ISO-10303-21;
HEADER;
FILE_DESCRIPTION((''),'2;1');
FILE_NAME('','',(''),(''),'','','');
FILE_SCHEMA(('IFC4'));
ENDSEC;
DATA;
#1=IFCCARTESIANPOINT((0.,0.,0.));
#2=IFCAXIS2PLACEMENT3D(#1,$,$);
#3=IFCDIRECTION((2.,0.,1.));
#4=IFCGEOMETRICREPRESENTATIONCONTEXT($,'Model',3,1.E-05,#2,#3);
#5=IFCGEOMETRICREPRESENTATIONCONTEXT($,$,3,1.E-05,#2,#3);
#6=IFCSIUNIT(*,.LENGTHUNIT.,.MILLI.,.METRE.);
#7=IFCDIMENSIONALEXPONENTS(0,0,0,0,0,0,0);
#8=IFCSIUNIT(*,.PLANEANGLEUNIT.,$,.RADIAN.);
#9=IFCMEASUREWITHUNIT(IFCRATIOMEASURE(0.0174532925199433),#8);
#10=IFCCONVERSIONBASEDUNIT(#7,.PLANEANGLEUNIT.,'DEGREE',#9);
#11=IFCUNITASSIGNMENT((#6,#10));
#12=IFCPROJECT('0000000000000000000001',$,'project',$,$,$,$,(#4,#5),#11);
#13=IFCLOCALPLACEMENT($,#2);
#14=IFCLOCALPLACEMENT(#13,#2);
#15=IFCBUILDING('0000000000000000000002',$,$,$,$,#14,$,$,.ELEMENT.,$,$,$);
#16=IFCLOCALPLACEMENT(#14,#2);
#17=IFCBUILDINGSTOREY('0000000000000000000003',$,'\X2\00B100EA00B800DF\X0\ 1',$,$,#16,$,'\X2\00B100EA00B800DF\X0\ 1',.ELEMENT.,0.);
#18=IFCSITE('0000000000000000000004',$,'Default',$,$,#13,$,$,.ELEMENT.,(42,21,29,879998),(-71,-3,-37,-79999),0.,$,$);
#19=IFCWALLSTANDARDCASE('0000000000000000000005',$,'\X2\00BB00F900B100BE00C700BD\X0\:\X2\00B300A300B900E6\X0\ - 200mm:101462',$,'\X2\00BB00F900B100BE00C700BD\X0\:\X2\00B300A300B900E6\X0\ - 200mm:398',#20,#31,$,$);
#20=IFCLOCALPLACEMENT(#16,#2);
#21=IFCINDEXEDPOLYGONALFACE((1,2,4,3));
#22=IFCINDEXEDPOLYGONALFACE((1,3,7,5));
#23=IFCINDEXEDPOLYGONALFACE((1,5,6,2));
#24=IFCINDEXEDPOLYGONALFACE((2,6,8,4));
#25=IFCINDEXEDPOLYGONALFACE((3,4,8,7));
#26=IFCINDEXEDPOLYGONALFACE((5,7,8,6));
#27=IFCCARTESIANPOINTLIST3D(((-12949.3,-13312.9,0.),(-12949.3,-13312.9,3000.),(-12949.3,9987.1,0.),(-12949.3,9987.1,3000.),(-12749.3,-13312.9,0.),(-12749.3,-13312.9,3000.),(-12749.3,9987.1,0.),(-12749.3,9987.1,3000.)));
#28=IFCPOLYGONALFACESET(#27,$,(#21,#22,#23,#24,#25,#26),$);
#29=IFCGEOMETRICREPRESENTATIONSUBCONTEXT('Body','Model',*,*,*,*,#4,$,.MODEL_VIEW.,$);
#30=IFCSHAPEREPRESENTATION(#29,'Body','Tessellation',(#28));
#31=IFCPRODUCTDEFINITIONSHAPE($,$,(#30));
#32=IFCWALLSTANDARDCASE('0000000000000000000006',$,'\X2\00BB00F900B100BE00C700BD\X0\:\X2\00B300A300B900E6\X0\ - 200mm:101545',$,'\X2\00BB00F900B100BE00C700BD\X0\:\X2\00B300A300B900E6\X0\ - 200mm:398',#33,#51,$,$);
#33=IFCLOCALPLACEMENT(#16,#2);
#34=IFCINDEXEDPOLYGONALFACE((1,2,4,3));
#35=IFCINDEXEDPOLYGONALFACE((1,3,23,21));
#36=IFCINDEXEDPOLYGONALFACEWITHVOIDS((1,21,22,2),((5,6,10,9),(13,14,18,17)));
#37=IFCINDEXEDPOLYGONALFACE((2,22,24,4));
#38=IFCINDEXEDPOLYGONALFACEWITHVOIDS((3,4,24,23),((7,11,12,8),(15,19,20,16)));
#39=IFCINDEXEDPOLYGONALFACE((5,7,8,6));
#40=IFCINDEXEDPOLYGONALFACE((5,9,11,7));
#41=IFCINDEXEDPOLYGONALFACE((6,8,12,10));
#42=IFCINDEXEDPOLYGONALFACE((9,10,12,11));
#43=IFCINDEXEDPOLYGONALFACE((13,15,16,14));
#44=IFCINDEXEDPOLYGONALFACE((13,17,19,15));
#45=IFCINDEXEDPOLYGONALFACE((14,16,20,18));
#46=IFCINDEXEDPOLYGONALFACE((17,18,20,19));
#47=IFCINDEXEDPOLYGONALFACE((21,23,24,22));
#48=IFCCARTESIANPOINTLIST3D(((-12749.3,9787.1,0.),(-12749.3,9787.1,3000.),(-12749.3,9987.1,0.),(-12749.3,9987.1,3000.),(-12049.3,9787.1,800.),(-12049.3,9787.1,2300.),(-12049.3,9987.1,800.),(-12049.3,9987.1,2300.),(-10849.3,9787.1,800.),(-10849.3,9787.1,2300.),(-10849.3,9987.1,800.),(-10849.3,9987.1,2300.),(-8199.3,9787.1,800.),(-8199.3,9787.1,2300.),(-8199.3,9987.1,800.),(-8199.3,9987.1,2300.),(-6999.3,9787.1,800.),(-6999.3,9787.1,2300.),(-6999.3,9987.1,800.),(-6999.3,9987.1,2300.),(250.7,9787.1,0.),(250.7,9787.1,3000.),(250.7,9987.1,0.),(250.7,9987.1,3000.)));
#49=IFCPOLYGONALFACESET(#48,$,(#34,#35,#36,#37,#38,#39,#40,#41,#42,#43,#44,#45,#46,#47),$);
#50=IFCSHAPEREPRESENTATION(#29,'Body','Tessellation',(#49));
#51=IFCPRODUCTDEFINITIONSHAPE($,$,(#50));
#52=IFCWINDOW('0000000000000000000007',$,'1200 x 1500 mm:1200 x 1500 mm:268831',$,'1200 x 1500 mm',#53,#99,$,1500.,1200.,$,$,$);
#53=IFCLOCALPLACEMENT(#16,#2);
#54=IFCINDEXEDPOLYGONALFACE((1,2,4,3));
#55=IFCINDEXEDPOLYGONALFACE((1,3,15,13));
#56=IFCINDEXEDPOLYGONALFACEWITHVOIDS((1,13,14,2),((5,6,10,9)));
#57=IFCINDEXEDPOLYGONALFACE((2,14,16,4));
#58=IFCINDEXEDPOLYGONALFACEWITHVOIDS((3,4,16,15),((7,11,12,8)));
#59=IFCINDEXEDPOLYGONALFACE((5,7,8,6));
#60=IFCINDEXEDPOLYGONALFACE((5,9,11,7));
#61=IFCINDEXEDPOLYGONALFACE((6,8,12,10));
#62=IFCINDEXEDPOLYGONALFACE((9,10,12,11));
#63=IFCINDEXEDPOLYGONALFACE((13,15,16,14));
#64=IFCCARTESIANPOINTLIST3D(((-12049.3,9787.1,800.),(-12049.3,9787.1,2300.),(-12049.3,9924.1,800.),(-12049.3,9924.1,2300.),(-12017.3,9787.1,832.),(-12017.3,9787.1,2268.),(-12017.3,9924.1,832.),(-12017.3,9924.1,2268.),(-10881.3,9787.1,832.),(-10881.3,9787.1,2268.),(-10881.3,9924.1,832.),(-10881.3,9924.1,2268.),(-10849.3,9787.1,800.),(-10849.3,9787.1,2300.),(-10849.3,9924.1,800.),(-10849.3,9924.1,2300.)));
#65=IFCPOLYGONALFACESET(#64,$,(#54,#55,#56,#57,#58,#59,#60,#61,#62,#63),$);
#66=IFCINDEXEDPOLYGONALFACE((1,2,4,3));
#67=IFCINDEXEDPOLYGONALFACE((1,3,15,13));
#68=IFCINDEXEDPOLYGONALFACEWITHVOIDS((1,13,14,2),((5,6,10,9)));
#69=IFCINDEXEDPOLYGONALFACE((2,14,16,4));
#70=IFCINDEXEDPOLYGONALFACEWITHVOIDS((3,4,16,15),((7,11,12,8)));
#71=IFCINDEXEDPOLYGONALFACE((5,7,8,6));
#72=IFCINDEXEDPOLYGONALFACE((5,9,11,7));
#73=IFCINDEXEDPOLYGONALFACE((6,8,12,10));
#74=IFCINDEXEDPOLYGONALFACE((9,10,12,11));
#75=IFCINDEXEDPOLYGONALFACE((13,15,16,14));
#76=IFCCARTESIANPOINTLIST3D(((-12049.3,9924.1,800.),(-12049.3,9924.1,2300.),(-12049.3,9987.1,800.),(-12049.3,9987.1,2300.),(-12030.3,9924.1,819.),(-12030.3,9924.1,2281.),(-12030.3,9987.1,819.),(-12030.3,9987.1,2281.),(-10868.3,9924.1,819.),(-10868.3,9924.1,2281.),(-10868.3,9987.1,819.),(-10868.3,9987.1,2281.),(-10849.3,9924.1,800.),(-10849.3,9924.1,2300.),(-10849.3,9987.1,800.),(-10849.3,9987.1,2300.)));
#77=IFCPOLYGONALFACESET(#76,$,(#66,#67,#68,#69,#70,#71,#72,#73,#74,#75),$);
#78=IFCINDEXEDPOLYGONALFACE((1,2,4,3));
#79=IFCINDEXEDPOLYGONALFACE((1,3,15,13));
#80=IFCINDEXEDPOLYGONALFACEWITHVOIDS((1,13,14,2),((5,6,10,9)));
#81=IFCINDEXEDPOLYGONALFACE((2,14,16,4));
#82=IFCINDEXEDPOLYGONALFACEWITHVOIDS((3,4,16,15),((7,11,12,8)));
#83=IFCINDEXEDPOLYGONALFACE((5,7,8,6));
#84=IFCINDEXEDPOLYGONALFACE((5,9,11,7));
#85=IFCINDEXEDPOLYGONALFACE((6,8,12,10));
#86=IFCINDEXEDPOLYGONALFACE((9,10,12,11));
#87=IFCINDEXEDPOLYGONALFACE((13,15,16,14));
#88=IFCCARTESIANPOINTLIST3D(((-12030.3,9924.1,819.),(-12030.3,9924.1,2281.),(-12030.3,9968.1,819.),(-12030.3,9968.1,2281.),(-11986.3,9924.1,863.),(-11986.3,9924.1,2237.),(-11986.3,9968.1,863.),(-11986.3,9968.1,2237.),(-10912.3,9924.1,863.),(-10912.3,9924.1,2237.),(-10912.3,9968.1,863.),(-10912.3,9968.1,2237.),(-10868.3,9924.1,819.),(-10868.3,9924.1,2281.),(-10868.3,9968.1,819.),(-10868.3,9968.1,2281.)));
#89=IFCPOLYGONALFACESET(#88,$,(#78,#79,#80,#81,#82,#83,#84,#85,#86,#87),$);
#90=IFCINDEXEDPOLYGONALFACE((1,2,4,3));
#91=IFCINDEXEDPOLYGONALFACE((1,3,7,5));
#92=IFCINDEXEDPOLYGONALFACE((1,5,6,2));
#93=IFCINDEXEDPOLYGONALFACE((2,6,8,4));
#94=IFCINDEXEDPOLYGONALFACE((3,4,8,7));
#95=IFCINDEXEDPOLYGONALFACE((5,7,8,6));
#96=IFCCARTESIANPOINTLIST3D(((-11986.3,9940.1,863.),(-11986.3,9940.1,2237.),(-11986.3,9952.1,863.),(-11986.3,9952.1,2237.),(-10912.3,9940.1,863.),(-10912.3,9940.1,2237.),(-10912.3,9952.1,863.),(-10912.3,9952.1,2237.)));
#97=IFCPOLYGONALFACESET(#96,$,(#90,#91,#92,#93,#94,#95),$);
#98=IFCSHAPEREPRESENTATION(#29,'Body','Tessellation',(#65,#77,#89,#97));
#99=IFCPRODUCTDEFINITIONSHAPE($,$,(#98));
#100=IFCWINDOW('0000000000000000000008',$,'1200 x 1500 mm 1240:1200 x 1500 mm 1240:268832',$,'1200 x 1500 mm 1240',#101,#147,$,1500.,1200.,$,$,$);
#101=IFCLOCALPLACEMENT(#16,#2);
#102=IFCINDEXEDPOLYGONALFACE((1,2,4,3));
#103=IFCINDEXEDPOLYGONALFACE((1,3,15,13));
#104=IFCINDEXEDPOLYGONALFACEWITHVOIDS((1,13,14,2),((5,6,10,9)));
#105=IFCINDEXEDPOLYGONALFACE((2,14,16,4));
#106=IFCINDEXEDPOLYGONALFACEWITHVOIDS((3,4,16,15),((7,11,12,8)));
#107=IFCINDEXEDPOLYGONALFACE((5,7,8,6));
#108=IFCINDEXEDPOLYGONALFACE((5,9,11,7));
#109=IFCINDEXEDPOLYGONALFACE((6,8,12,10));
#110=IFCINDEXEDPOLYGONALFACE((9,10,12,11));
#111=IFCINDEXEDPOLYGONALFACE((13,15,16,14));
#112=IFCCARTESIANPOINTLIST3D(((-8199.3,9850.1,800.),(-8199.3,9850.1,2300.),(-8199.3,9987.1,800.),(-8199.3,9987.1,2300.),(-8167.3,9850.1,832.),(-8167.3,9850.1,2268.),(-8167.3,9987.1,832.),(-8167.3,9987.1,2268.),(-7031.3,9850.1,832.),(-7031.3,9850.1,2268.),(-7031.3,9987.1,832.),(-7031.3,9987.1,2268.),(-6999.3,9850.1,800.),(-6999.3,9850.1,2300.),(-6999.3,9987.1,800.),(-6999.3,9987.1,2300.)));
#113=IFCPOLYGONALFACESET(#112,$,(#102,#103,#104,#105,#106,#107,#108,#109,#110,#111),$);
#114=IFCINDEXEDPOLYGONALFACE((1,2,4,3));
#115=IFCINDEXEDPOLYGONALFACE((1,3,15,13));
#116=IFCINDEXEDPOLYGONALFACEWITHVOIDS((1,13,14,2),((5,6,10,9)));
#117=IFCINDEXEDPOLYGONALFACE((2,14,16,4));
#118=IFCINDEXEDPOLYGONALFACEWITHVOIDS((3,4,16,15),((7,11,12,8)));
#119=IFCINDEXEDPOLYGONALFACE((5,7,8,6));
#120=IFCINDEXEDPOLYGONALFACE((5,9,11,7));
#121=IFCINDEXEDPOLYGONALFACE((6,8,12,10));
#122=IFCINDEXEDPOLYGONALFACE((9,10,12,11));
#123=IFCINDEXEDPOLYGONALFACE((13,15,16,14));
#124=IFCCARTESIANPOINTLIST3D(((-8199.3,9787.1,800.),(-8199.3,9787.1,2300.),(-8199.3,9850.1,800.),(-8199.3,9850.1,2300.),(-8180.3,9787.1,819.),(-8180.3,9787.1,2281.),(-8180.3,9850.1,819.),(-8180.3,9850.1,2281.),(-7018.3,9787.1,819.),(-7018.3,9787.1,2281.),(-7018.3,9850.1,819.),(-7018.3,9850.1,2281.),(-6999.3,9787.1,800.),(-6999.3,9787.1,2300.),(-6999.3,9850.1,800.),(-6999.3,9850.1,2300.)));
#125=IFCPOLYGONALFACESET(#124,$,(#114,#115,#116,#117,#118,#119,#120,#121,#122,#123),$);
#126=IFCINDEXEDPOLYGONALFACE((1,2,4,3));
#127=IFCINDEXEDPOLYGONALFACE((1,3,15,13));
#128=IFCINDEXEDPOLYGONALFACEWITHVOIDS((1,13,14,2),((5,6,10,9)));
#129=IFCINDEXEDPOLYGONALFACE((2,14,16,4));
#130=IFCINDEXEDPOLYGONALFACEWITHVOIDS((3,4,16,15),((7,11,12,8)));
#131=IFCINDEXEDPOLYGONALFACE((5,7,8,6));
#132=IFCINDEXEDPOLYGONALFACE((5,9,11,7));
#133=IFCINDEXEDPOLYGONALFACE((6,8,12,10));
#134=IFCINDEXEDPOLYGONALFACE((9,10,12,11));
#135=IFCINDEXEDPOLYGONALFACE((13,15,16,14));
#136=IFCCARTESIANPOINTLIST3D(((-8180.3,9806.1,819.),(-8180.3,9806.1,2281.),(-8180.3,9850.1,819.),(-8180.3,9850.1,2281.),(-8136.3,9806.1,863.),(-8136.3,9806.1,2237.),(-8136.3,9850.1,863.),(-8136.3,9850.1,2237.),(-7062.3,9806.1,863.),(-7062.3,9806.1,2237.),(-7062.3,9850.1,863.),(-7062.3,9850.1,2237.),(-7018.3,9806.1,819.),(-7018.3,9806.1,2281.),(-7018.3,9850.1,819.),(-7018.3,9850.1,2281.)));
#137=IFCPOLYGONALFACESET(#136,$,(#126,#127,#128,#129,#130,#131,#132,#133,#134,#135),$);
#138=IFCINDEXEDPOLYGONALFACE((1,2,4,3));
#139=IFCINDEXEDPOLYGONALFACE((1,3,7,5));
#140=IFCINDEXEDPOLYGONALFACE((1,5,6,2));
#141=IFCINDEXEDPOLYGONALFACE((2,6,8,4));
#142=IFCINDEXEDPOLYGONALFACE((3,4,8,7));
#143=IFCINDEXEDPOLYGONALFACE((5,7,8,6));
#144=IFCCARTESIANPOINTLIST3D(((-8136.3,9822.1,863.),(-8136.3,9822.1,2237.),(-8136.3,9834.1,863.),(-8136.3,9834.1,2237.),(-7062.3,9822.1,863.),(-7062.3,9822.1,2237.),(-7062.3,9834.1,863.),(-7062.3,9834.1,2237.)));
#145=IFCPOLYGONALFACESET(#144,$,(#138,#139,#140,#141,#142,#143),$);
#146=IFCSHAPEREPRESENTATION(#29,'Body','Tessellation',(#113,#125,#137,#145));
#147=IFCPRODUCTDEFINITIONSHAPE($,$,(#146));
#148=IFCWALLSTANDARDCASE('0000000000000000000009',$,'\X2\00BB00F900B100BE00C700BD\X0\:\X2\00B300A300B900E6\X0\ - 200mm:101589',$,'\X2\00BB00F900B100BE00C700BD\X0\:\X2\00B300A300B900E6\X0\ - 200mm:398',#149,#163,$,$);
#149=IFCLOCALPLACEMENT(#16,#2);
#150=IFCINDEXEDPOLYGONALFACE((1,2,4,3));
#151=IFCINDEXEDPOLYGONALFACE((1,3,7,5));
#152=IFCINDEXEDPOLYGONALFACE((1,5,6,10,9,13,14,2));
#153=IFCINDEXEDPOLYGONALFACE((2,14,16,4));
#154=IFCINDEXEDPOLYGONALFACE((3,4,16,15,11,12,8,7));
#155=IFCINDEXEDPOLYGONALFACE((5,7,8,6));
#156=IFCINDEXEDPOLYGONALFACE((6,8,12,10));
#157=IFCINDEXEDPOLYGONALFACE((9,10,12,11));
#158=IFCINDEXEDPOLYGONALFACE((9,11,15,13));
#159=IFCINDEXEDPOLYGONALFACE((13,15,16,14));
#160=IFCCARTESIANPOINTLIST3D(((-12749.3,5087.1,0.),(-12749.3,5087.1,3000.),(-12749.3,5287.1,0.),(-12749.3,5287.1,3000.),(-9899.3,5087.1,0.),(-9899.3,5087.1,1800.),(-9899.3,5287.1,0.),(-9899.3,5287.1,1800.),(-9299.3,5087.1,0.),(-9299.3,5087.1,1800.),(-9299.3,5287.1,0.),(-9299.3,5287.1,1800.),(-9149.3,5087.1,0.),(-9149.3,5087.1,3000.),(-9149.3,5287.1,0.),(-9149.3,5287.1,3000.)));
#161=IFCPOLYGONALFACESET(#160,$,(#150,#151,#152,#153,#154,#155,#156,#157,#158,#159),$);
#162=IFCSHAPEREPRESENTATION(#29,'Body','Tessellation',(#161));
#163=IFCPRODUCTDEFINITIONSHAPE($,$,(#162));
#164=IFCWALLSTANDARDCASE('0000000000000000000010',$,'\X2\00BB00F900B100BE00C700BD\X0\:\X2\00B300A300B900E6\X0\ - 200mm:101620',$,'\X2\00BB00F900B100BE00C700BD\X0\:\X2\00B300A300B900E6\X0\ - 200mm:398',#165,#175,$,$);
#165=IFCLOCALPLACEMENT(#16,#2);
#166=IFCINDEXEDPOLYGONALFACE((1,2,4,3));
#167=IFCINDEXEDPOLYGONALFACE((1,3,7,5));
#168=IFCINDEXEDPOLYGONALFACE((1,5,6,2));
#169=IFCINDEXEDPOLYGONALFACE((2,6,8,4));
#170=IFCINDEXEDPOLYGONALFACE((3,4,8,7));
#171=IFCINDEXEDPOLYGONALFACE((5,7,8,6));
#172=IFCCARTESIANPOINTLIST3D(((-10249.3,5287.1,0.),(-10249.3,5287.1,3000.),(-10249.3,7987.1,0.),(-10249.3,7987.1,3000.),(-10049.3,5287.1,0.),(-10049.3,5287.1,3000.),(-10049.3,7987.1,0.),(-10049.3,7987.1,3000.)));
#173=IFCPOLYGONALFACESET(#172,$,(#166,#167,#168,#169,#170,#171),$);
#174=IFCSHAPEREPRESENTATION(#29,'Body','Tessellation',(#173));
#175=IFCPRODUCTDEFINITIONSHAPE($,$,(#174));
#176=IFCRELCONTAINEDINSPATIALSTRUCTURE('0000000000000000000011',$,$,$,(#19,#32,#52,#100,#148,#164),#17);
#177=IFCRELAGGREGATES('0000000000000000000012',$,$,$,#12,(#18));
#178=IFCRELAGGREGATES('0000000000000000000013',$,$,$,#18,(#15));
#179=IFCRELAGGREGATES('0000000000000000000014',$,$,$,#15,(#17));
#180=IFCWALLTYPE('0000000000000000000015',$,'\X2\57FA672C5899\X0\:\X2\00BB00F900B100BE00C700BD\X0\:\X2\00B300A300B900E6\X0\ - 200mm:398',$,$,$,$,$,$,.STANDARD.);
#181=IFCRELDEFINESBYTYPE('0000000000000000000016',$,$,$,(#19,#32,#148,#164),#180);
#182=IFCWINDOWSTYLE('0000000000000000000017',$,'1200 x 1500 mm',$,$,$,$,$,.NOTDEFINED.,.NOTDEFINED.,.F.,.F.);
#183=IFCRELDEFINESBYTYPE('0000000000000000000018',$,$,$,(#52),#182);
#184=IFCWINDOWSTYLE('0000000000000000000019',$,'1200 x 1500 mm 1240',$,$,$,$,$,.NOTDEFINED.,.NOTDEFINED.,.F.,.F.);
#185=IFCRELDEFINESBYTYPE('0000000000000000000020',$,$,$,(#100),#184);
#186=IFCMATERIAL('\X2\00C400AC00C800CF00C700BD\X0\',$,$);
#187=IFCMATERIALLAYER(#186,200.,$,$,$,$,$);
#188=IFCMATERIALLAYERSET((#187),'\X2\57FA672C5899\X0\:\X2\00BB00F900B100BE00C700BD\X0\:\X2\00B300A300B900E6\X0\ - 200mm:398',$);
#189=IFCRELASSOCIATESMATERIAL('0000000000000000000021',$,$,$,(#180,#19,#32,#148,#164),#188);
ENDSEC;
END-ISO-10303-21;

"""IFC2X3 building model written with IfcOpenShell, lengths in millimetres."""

from ifc_helpers import new_model, entity, si_unit, converted_unit, direction, frame, frame_2d, origin, origin_2d_with_axis, place, context, subcontext, project, spatial, polyline, rectangle, outline, extrude, source, transform, mapped, material, layer, layer_set, layer_usage, type_object, type_shapes, element, fill, save


model = new_model("IFC2X3")

# Units and contexts
model_context = context("Model", 3, precision=1e-05, world=origin(), true_north=direction((2.0, 0.0, 1.0)))
context_of_model = context(None, 3, precision=1e-05, world=origin(), true_north=direction((2.0, 0.0, 1.0)))
body_context = subcontext(model_context, "Body", "Model", "MODEL_VIEW")
ifc_project = project(units=[si_unit("LENGTHUNIT", "METRE", prefix="MILLI"), converted_unit("PLANEANGLEUNIT", "DEGREE", entity("IfcRatioMeasure", 0.0174532925199433), si_unit("PLANEANGLEUNIT", "RADIAN"), dimensions=[0, 0, 0, 0, 0, 0, 0])], contexts=[model_context, context_of_model])

# Site, building, storey
site_placement = place(None, origin())
site = spatial("IfcSite", under=ifc_project, at=site_placement, Name="Default", CompositionType="ELEMENT", RefLatitude=(42, 21, 29, 879998), RefLongitude=(-71, -3, -37, -79999), RefElevation=0.0)
building_placement = place(site_placement, origin())
building = spatial("IfcBuilding", under=site, at=building_placement, CompositionType="ELEMENT")
storey_placement = place(building_placement, origin())
storey = spatial("IfcBuildingStorey", under=building, at=storey_placement, Name="±ê¸ß 1", LongName="±ê¸ß 1", CompositionType="ELEMENT", Elevation=0.0)

# Wall
ifc_material = material(Name="Ä¬ÈÏÇ½")
ifc_layer = layer(ifc_material, 200.0)
ifc_layer_set = layer_set([ifc_layer], Name="基本墙:»ù±¾Ç½:³£¹æ - 200mm:398")
ifc_layer_usage_1 = layer_usage(ifc_layer_set, "AXIS2", "NEGATIVE", 100.0)
wall_type = type_object("IfcWallType", Name="基本墙:»ù±¾Ç½:³£¹æ - 200mm:398", PredefinedType="STANDARD", material=ifc_layer_set)
wall_1_placement = place(storey_placement, frame((-12849.3, 9987.1, 0.0), z_axis=(0.0, 0.0, 1.0), x_axis=(0.0, -1.0, 0.0)))
element("IfcWallStandardCase", 1, at=wall_1_placement, inside=storey, type_object=wall_type, material=ifc_layer_usage_1, Name="»ù±¾Ç½:³£¹æ - 200mm:101462", ObjectType="»ù±¾Ç½:³£¹æ - 200mm:398", context=body_context, shape_type="SweptSolid", body=[
    extrude(rectangle(XDim=23300.0, YDim=200.0, at=frame_2d((11650.0, 0.0), x_axis=(-1.0, 0.0))), origin(), (0.0, 0.0, 1.0), 3000.0),
])

# Wall, openings, windows
ifc_layer_usage_2 = layer_usage(ifc_layer_set, "AXIS2", "NEGATIVE", 100.0)
wall_2_placement = place(storey_placement, frame((250.7, 9887.1, 0.0), z_axis=(0.0, 0.0, 1.0), x_axis=(-1.0, 0.0, 0.0)))
wall_2 = element("IfcWallStandardCase", 2, at=wall_2_placement, inside=storey, type_object=wall_type, material=ifc_layer_usage_2, Name="»ù±¾Ç½:³£¹æ - 200mm:101545", ObjectType="»ù±¾Ç½:³£¹æ - 200mm:398", context=body_context, shape_type="SweptSolid", body=[
    extrude(rectangle(XDim=13000.0, YDim=200.0, at=frame_2d((6500.0, 0.0), x_axis=(-1.0, 0.0))), origin(), (0.0, 0.0, 1.0), 3000.0),
])
opening_1_placement = place(wall_2_placement, origin())
opening_1 = element("IfcOpeningElement", 3, at=opening_1_placement, cuts=wall_2, ObjectType="Opening", context=body_context, shape_type="SweptSolid", body=[
    extrude(rectangle(XDim=1500.0, YDim=1200.0, at=frame_2d((0.0, 0.0), x_axis=(0.0, 1.0))), frame((11700.0, -102.0, 1550.0), z_axis=(0.0, 1.0, 0.0), x_axis=(1.0, 0.0, 0.0)), (0.0, 0.0, 1.0), 204.0),
])
opening_2_placement = place(wall_2_placement, origin())
opening_2 = element("IfcOpeningElement", 4, at=opening_2_placement, cuts=wall_2, ObjectType="Opening", context=body_context, shape_type="SweptSolid", body=[
    extrude(rectangle(XDim=1500.0, YDim=1200.0, at=frame_2d((0.0, 0.0), x_axis=(0.0, 1.0))), frame((7850.0, -102.0, 1550.0), z_axis=(0.0, 1.0, 0.0), x_axis=(1.0, 0.0, 0.0)), (0.0, 0.0, 1.0), 204.0),
])
window_style_1 = type_object("IfcWindowStyle", Name="1200 x 1500 mm", ConstructionType="NOTDEFINED", OperationType="NOTDEFINED", ParameterTakesPrecedence=False, Sizeable=False)
shared_shape_1 = source(origin(), body_context, "Body", "SweptSolid", [
    extrude(outline(polyline([(-750.0, -600.0), (750.0, -600.0), (750.0, 600.0), (-750.0, 600.0), (-750.0, -600.0)]), holes=[polyline([(718.0, 568.0), (718.0, -568.0), (-718.0, -568.0), (-718.0, 568.0), (718.0, 568.0)])]), frame((600.0, 2.0, 750.0), z_axis=(0.0, 1.0, 0.0), x_axis=(0.0, 0.0, -1.0)), (0.0, 0.0, 1.0), 137.0),
    extrude(outline(polyline([(-750.0, -600.0), (750.0, -600.0), (750.0, 600.0), (-750.0, 600.0), (-750.0, -600.0)]), holes=[polyline([(731.0, 581.0), (731.0, -581.0), (-731.0, -581.0), (-731.0, 581.0), (731.0, 581.0)])]), frame((600.0, 139.0, 750.0), z_axis=(0.0, 1.0, 0.0), x_axis=(0.0, 0.0, -1.0)), (0.0, 0.0, 1.0), 63.0),
    extrude(outline(polyline([(-731.0, -581.0), (731.0, -581.0), (731.0, 581.0), (-731.0, 581.0), (-731.0, -581.0)]), holes=[polyline([(687.0, 537.0), (687.0, -537.0), (-687.0, -537.0), (-687.0, 537.0), (687.0, 537.0)])]), frame((600.0, 139.0, 750.0), z_axis=(0.0, 1.0, 0.0), x_axis=(0.0, 0.0, -1.0)), (0.0, 0.0, 1.0), 44.0),
    extrude(rectangle(XDim=1074.0, YDim=12.0, at=origin_2d_with_axis()), frame((600.0, 161.0, 63.0)), (0.0, 0.0, 1.0), 1374.0),
])
type_shapes(window_style_1, [shared_shape_1])
window_1_placement = place(opening_1_placement, frame((12300.0, 102.0, 800.0), z_axis=(0.0, 0.0, 1.0), x_axis=(-1.0, 0.0, 0.0)))
window_1 = element("IfcWindow", 5, at=window_1_placement, inside=storey, type_object=window_style_1, Name="1200 x 1500 mm:1200 x 1500 mm:268831", ObjectType="1200 x 1500 mm", OverallHeight=1500.0, OverallWidth=1200.0, context=body_context, shape_type="MappedRepresentation", body=[
    mapped(shared_shape_1, transform((0.0, 0.0, 0.0), scale=1.0)),
])
fill(opening_1, window_1)
window_style_2 = type_object("IfcWindowStyle", Name="1200 x 1500 mm 1240", ConstructionType="NOTDEFINED", OperationType="NOTDEFINED", ParameterTakesPrecedence=False, Sizeable=False)
shared_shape_2 = source(origin(), body_context, "Body", "SweptSolid", [
    extrude(outline(polyline([(-750.0, -600.0), (750.0, -600.0), (750.0, 600.0), (-750.0, 600.0), (-750.0, -600.0)]), holes=[polyline([(718.0, 568.0), (718.0, -568.0), (-718.0, -568.0), (-718.0, 568.0), (718.0, 568.0)])]), frame((600.0, -202.0, 750.0), z_axis=(0.0, 1.0, 0.0), x_axis=(0.0, 0.0, -1.0)), (0.0, 0.0, 1.0), 137.0),
    extrude(outline(polyline([(-750.0, -600.0), (750.0, -600.0), (750.0, 600.0), (-750.0, 600.0), (-750.0, -600.0)]), holes=[polyline([(731.0, 581.0), (731.0, -581.0), (-731.0, -581.0), (-731.0, 581.0), (731.0, 581.0)])]), frame((600.0, -65.0, 750.0), z_axis=(0.0, 1.0, 0.0), x_axis=(0.0, 0.0, -1.0)), (0.0, 0.0, 1.0), 63.0),
    extrude(outline(polyline([(-731.0, -581.0), (731.0, -581.0), (731.0, 581.0), (-731.0, 581.0), (-731.0, -581.0)]), holes=[polyline([(687.0, 537.0), (687.0, -537.0), (-687.0, -537.0), (-687.0, 537.0), (687.0, 537.0)])]), frame((600.0, -65.0, 750.0), z_axis=(0.0, 1.0, 0.0), x_axis=(0.0, 0.0, -1.0)), (0.0, 0.0, 1.0), 44.0),
    extrude(rectangle(XDim=1074.0, YDim=12.0, at=origin_2d_with_axis()), frame((600.0, -43.0, 63.0)), (0.0, 0.0, 1.0), 1374.0),
])
type_shapes(window_style_2, [shared_shape_2])
window_2_placement = place(opening_2_placement, frame((7250.0, 102.0, 800.0)))
window_2 = element("IfcWindow", 6, at=window_2_placement, inside=storey, type_object=window_style_2, Name="1200 x 1500 mm 1240:1200 x 1500 mm 1240:268832", ObjectType="1200 x 1500 mm 1240", OverallHeight=1500.0, OverallWidth=1200.0, context=body_context, shape_type="MappedRepresentation", body=[
    mapped(shared_shape_2, transform((0.0, 0.0, 0.0), scale=1.0)),
])
fill(opening_2, window_2)

# Wall, opening
ifc_layer_usage_3 = layer_usage(ifc_layer_set, "AXIS2", "NEGATIVE", 100.0)
wall_3_placement = place(storey_placement, frame((-12749.3, 5187.1, 0.0)))
wall_3 = element("IfcWallStandardCase", 7, at=wall_3_placement, inside=storey, type_object=wall_type, material=ifc_layer_usage_3, Name="»ù±¾Ç½:³£¹æ - 200mm:101589", ObjectType="»ù±¾Ç½:³£¹æ - 200mm:398", context=body_context, shape_type="SweptSolid", body=[
    extrude(rectangle(XDim=3600.0, YDim=200.0, at=frame_2d((1800.0, 0.0), x_axis=(-1.0, 0.0))), origin(), (0.0, 0.0, 1.0), 3000.0),
])
opening_3_placement = place(wall_3_placement, origin())
element("IfcOpeningElement", 8, at=opening_3_placement, cuts=wall_3, ObjectType="Opening", context=body_context, shape_type="SweptSolid", body=[
    extrude(rectangle(XDim=1800.0, YDim=600.0, at=origin_2d_with_axis()), frame((3150.0, -102.0, 900.0), z_axis=(0.0, 1.0, 0.0), x_axis=(0.0, 0.0, -1.0)), (0.0, 0.0, 1.0), 204.0),
])

# Wall
ifc_layer_usage_4 = layer_usage(ifc_layer_set, "AXIS2", "NEGATIVE", 100.0)
wall_4_placement = place(storey_placement, frame((-10149.3, 5287.1, 0.0), z_axis=(0.0, 0.0, 1.0), x_axis=(0.0, 1.0, 0.0)))
element("IfcWallStandardCase", 9, at=wall_4_placement, inside=storey, type_object=wall_type, material=ifc_layer_usage_4, Name="»ù±¾Ç½:³£¹æ - 200mm:101620", ObjectType="»ù±¾Ç½:³£¹æ - 200mm:398", context=body_context, shape_type="SweptSolid", body=[
    extrude(rectangle(XDim=2700.0, YDim=200.0, at=frame_2d((1350.0, 0.0), x_axis=(-1.0, 0.0))), origin(), (0.0, 0.0, 1.0), 3000.0),
])

save(model, "model.ifc")
